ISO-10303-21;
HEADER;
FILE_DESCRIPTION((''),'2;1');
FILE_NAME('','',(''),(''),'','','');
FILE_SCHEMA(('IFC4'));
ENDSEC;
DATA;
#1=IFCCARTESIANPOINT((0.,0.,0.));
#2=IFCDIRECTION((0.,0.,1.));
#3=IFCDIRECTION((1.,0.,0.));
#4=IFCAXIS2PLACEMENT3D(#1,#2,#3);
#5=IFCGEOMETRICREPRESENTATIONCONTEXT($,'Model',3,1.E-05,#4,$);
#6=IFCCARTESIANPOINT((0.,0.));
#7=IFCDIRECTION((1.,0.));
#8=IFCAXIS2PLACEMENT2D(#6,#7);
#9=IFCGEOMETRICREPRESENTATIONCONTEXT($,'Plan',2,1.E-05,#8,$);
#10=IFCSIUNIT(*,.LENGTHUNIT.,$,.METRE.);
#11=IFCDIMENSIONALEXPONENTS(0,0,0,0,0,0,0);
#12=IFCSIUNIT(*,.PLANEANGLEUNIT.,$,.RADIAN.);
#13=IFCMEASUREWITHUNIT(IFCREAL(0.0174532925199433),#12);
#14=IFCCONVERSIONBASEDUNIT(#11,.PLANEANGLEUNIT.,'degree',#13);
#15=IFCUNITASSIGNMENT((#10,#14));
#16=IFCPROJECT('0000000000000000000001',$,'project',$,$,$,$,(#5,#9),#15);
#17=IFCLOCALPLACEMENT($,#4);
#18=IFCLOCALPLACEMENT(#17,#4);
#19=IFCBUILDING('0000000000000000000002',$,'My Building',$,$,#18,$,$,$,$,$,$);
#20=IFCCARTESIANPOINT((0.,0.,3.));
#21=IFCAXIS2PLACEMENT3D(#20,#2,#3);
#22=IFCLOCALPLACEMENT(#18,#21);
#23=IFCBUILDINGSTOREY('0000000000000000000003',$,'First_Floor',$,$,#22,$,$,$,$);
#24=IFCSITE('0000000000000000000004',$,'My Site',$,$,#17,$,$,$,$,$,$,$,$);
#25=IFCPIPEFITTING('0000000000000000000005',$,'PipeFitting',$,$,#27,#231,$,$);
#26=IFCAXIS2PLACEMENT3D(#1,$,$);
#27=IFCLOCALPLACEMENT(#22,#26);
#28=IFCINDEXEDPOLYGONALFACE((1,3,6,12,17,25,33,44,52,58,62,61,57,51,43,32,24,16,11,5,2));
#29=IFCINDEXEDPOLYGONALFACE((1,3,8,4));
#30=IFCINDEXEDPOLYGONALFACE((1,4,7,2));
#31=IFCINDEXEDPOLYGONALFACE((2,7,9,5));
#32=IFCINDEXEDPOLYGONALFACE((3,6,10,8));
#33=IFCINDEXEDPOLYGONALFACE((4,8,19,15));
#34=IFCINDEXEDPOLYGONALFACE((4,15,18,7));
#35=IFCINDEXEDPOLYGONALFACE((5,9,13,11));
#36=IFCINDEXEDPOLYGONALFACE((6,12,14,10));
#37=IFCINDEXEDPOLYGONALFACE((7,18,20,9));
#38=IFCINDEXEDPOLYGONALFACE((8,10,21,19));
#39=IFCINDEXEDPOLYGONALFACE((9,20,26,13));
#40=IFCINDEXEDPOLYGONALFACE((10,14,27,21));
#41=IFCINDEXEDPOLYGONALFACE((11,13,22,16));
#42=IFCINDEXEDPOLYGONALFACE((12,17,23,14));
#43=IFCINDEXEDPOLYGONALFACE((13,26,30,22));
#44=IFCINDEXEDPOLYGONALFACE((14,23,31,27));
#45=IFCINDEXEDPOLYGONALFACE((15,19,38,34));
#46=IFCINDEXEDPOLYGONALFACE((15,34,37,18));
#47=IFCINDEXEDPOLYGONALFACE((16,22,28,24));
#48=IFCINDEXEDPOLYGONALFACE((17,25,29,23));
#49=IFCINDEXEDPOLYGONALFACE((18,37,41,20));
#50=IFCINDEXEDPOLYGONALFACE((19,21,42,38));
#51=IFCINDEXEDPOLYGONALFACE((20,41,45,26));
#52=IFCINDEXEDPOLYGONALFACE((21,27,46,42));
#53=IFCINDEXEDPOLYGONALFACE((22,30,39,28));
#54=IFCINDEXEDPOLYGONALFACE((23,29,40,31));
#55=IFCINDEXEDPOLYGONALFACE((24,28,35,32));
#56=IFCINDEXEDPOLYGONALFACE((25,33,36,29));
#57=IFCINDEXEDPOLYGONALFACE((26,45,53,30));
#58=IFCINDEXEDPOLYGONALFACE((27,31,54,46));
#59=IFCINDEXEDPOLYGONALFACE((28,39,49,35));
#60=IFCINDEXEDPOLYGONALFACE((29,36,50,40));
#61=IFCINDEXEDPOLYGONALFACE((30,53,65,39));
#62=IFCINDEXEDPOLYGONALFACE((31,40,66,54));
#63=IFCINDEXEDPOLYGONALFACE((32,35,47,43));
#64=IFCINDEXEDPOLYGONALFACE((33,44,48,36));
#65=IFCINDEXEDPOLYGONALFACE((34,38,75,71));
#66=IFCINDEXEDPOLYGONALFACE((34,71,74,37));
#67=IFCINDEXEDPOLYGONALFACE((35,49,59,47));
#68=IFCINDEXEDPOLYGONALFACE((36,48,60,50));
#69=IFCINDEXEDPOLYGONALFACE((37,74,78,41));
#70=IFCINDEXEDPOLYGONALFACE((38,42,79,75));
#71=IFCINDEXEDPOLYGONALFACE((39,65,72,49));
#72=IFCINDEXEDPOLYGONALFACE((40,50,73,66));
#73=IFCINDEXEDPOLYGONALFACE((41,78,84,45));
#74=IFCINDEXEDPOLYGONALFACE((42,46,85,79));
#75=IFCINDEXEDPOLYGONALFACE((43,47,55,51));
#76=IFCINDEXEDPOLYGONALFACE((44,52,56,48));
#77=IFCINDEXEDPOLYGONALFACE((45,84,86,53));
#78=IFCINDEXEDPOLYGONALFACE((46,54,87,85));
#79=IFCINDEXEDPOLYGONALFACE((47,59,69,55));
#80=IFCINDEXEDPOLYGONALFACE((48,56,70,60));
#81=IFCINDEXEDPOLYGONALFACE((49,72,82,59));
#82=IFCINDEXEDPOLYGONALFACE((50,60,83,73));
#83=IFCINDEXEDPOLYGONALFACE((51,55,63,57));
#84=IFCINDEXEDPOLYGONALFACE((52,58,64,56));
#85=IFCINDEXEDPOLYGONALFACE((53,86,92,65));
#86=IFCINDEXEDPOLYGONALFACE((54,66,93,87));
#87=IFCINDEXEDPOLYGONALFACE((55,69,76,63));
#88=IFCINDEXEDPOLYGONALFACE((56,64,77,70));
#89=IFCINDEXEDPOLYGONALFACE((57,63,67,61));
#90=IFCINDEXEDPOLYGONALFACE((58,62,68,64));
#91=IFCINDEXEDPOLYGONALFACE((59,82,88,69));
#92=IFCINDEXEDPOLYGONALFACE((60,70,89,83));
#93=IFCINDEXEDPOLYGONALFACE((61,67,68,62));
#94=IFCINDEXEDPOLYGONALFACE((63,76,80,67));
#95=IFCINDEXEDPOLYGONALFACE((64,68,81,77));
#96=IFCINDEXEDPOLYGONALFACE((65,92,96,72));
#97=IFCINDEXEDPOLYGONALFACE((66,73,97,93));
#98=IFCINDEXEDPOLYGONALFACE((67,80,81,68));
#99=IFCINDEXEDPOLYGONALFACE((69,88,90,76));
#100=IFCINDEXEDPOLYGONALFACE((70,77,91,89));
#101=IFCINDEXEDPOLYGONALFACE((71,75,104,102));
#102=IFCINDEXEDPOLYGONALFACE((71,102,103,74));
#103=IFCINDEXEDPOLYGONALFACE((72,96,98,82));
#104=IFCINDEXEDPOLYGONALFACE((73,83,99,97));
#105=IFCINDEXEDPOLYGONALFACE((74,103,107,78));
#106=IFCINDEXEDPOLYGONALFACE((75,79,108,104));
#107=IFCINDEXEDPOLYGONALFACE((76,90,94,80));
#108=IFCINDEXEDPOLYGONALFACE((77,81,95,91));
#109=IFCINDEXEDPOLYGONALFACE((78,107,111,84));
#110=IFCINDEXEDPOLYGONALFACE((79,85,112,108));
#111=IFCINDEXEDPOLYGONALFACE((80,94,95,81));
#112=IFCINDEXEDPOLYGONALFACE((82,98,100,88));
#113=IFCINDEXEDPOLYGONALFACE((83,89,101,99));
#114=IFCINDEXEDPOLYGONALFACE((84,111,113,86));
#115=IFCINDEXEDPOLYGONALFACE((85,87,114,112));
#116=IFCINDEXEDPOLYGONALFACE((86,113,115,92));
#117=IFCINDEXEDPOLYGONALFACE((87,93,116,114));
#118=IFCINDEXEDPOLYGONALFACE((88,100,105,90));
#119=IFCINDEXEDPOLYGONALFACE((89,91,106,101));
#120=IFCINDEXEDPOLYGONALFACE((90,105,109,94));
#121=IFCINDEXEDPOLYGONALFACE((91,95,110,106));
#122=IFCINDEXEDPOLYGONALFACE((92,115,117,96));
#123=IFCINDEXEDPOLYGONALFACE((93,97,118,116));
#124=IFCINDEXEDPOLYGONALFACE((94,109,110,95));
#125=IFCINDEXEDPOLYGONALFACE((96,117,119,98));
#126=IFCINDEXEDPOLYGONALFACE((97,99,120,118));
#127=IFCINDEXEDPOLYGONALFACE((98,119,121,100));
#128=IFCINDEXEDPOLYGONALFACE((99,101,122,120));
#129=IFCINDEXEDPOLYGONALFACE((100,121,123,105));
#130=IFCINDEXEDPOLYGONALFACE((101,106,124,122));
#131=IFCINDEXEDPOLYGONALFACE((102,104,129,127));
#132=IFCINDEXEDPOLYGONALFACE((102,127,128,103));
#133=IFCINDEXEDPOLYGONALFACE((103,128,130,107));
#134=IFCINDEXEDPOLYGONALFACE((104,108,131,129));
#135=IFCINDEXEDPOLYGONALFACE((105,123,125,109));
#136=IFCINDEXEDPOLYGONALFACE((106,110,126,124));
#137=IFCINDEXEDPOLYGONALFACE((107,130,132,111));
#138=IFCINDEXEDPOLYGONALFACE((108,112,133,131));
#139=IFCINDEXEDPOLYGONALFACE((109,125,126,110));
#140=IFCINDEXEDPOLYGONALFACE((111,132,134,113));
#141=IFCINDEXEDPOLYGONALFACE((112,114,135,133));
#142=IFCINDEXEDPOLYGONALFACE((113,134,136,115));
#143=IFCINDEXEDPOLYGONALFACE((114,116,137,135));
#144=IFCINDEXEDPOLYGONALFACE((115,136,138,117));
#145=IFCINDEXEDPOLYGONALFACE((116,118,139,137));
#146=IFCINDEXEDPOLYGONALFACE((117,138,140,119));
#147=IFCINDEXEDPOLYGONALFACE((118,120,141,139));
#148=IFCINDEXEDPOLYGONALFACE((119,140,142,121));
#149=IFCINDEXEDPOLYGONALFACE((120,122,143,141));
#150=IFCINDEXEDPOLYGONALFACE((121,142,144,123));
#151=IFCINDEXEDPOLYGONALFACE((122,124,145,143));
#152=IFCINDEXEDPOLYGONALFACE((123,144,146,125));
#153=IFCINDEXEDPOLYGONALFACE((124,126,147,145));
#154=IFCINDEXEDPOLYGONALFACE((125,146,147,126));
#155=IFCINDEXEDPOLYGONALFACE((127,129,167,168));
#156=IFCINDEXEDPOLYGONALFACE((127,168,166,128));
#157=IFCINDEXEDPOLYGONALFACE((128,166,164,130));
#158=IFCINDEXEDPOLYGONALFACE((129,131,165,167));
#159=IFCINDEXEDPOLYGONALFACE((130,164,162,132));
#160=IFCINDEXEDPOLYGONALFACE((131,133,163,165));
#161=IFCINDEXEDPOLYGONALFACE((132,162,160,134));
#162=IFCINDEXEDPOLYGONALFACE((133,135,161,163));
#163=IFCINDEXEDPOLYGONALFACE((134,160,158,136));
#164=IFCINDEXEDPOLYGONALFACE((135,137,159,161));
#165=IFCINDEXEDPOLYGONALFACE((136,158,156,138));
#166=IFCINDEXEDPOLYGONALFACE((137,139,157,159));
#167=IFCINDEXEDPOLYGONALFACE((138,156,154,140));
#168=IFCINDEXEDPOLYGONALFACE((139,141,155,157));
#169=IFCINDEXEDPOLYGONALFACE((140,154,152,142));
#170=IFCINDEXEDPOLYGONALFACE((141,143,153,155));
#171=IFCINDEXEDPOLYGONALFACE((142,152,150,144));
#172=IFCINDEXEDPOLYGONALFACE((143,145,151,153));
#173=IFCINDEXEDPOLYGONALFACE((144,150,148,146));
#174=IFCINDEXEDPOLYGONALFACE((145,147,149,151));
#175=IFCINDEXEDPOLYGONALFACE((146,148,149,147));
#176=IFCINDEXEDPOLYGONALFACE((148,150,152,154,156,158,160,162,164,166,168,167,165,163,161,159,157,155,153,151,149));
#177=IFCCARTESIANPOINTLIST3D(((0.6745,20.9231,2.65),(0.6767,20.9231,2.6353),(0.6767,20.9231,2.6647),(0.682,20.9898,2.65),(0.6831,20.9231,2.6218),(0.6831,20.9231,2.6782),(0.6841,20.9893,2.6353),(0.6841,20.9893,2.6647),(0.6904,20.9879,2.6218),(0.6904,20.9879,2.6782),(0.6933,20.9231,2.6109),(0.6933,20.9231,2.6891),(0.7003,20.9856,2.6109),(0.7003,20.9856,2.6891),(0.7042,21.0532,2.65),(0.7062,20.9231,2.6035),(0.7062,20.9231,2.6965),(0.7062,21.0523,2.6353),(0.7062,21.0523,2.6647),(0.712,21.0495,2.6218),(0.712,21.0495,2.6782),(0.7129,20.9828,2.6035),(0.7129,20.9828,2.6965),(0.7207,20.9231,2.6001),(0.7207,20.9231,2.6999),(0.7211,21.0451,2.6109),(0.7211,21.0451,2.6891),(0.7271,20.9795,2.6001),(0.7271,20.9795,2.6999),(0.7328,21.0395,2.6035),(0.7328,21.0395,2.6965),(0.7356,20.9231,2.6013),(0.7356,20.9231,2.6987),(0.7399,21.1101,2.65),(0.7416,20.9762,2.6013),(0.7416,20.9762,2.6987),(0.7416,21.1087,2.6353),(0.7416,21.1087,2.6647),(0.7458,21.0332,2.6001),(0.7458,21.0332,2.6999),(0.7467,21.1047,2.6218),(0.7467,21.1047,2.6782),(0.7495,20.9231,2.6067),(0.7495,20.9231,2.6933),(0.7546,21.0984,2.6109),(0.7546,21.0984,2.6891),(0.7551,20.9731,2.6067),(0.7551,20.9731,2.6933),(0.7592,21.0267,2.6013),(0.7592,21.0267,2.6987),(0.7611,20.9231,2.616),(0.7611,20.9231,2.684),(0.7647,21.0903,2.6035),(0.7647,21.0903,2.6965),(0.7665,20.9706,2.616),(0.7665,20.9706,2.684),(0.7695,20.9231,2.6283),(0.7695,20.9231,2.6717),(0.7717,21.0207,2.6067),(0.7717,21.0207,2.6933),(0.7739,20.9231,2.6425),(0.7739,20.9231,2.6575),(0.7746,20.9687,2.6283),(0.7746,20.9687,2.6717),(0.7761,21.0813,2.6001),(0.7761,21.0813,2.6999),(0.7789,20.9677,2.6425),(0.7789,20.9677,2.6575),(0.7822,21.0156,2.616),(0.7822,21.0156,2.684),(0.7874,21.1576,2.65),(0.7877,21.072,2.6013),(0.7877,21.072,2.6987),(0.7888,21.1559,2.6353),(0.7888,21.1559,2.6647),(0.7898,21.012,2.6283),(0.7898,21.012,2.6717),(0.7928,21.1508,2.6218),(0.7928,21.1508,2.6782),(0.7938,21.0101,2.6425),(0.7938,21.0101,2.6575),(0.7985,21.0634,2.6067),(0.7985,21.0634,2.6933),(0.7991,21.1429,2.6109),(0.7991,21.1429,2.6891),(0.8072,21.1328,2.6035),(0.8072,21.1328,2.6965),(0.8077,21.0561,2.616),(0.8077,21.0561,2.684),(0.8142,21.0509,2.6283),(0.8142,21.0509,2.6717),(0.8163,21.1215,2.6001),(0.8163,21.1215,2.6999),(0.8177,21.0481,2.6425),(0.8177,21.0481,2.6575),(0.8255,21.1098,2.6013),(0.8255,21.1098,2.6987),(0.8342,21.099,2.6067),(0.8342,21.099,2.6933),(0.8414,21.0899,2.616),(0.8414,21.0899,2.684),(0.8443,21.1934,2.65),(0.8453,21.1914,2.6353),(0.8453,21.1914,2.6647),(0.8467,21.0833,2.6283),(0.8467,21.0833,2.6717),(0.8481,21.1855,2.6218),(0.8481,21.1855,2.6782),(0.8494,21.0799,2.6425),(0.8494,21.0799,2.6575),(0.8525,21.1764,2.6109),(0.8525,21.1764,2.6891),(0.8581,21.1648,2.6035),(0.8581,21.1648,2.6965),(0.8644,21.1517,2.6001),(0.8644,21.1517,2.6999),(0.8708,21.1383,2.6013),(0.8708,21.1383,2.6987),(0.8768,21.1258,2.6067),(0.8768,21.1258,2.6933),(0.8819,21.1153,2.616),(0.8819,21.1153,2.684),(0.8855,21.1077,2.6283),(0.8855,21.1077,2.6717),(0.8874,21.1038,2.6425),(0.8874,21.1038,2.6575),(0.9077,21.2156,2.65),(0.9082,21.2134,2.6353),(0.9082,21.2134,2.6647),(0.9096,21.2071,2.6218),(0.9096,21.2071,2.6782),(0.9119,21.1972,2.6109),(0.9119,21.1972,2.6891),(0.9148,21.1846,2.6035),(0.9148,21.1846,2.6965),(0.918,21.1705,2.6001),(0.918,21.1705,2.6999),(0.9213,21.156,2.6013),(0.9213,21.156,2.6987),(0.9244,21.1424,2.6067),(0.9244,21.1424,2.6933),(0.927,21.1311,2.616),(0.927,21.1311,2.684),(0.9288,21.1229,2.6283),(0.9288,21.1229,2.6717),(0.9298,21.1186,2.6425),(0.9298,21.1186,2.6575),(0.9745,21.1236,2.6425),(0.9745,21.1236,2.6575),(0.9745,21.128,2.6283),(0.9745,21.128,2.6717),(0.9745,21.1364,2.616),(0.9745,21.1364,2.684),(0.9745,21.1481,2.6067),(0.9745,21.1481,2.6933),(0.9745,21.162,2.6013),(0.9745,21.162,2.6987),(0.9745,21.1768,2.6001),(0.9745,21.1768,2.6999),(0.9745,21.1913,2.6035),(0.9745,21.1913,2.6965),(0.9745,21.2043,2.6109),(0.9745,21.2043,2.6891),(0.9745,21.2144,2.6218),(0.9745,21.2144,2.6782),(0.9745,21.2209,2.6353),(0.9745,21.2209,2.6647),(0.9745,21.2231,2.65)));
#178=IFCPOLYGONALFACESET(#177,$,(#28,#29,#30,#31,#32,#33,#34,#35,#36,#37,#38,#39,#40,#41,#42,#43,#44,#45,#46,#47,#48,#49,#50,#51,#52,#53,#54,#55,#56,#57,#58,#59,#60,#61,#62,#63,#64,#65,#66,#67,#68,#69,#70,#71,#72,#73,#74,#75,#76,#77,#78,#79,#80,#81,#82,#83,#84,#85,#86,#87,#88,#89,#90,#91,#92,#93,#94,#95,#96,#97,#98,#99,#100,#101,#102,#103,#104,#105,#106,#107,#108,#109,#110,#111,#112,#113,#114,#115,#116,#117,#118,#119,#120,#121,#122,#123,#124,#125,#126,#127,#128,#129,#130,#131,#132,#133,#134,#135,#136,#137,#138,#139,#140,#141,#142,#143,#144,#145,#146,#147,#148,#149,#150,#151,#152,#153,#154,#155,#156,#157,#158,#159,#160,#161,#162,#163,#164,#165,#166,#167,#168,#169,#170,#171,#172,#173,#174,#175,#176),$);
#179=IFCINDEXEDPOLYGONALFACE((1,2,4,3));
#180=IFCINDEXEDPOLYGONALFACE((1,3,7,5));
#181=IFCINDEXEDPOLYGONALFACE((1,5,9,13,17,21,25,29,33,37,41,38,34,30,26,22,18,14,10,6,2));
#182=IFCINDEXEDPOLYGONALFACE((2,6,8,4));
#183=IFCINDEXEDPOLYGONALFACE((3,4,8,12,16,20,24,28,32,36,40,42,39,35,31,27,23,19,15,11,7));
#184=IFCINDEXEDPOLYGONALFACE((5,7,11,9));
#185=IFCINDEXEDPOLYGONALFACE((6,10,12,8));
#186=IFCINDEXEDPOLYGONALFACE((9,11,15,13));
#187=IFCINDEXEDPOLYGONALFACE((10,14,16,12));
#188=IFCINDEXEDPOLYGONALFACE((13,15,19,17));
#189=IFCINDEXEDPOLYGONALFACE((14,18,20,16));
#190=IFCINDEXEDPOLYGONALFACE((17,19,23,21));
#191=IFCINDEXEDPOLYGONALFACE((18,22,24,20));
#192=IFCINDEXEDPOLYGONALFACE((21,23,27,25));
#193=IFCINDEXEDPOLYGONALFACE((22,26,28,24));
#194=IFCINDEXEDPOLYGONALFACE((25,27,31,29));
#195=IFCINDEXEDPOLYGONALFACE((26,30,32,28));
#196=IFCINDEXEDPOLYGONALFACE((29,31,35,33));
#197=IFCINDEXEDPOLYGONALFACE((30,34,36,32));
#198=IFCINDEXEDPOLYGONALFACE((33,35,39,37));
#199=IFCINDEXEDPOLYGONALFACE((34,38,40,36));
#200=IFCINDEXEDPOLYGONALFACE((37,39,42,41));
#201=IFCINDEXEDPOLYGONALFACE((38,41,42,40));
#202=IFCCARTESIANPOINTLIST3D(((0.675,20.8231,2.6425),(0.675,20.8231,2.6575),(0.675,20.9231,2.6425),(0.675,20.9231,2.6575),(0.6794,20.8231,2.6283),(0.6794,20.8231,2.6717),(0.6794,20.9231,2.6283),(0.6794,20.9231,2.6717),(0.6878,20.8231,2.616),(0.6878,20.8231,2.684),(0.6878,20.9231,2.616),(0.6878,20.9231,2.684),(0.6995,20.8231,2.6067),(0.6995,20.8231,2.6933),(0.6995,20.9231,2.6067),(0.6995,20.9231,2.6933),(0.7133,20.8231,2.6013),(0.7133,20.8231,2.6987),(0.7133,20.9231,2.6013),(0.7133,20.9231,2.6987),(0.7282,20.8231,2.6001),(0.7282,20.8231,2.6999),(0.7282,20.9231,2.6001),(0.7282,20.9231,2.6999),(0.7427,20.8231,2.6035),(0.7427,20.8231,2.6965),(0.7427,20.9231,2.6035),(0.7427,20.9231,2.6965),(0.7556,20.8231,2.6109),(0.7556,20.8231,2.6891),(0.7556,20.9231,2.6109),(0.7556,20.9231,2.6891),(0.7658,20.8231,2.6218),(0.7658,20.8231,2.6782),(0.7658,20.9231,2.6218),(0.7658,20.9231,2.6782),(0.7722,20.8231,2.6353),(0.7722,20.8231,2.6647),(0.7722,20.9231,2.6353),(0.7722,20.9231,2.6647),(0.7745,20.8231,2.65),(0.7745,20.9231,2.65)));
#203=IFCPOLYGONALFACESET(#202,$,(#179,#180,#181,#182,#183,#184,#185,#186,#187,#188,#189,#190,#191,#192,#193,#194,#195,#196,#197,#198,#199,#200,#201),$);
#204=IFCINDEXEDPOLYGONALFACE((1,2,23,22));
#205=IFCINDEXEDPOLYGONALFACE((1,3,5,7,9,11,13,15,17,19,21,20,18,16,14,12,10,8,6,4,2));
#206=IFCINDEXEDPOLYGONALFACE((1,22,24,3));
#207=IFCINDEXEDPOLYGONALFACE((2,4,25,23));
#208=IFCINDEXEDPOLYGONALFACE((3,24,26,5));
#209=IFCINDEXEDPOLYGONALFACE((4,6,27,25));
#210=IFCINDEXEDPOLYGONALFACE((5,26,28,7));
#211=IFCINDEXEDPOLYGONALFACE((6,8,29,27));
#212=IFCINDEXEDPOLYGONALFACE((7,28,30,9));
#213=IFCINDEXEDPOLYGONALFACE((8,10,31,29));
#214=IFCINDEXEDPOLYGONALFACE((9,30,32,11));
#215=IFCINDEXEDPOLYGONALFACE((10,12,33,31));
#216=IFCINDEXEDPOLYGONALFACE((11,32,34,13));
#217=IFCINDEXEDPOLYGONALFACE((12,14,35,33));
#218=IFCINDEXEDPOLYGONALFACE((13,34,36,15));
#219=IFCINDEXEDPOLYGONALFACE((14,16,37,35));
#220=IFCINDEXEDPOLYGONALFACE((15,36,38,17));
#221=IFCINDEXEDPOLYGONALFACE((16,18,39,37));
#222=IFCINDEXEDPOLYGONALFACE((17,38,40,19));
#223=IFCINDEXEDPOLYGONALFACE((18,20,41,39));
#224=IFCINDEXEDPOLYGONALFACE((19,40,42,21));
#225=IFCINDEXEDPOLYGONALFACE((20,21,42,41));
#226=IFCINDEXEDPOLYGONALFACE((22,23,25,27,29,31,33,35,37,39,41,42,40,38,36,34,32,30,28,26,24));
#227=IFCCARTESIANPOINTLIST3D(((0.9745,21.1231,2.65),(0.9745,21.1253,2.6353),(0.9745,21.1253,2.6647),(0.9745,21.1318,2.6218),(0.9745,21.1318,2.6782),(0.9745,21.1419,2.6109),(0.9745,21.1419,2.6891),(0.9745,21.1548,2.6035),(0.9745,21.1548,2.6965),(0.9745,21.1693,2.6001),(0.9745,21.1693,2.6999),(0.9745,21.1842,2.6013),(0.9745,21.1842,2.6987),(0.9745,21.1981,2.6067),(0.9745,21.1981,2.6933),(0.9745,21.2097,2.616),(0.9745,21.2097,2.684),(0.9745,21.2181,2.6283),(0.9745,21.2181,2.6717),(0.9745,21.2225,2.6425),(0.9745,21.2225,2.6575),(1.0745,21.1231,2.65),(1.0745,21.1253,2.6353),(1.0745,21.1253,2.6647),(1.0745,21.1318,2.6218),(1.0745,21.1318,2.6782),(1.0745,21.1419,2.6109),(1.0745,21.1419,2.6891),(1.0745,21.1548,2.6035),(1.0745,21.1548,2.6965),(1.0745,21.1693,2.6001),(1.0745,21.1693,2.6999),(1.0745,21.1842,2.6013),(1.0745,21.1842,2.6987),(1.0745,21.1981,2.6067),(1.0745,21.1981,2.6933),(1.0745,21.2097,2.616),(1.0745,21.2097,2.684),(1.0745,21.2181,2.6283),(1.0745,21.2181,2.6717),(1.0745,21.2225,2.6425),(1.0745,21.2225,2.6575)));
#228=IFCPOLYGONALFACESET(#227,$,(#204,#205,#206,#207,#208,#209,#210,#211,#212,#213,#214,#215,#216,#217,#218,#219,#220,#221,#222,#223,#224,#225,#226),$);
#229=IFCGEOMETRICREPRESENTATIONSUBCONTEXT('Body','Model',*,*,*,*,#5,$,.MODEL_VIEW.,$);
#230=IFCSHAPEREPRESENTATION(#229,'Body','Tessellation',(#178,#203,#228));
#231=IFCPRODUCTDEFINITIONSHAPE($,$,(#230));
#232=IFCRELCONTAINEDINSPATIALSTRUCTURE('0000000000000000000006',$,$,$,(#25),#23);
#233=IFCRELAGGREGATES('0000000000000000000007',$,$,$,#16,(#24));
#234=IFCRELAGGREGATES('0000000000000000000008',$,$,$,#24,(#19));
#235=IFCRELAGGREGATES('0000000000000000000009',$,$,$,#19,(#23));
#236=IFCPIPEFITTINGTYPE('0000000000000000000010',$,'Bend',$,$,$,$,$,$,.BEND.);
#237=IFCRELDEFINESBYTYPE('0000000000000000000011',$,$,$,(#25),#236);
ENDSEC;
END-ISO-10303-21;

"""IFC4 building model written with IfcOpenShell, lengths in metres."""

from ifc_helpers import new_model, entity, si_unit, converted_unit, frame, origin_with_axes, origin_2d_with_axis, place, context, subcontext, project, spatial, circle, extrude, source, transform, mapped, type_object, type_shapes, element, save


model = new_model("IFC4")

# Units and contexts
model_context = context("Model", 3, precision=1e-05, world=origin_with_axes())
plan_context = context("Plan", 2, precision=1e-05, world=origin_2d_with_axis())
body_context = subcontext(model_context, "Body", "Model", "MODEL_VIEW")
ifc_project = project(units=[si_unit("LENGTHUNIT", "METRE"), converted_unit("PLANEANGLEUNIT", "degree", entity("IfcReal", 0.0174532925199433), si_unit("PLANEANGLEUNIT", "RADIAN"), dimensions=[0, 0, 0, 0, 0, 0, 0])], contexts=[model_context, plan_context])

# Site, building, storey
site_placement = place(None, origin_with_axes())
site = spatial("IfcSite", under=ifc_project, at=site_placement, Name="My Site")
building_placement = place(site_placement, origin_with_axes())
building = spatial("IfcBuilding", under=site, at=building_placement, Name="My Building")
storey_placement = place(building_placement, frame((0.0, 0.0, 3.0), z_axis=(0.0, 0.0, 1.0), x_axis=(1.0, 0.0, 0.0)))
storey = spatial("IfcBuildingStorey", under=building, at=storey_placement, Name="First_Floor")

# Pipe fitting
pipe_fitting_type = type_object("IfcPipeFittingType", Name="Bend", PredefinedType="BEND")
shared_shape = source(origin_with_axes(), body_context, "Body", "SolidModel", [
    entity("IfcSweptDiskSolid", entity("IfcIndexedPolyCurve", entity("IfcCartesianPointList3D", [[0.0, 0.0, -0.1], [0.0732, 0.0, -0.2768], [0.25, 0.0, -0.35]]), [entity("IfcArcIndex", [1, 2, 3])]), 0.05),
    extrude(circle(Radius=0.05), origin_with_axes(), (0.0, 0.0, -1.0), 0.1),
    extrude(circle(Radius=0.05), frame((0.25, 0.0, -0.35), z_axis=(1.0, 0.0, 0.0), x_axis=(0.0, 0.0, 1.0)), (0.0, 0.0, 1.0), 0.1),
])
type_shapes(pipe_fitting_type, [shared_shape])
for number, where, z_axis, x_axis, name in (
    (1, (0.7245, 20.8231, 2.65), (0.0, -1.0, 0.0), (1.0, 0.0, 0.0), "PipeFitting"),
):
    element("IfcPipeFitting", number, at=place(storey_placement, frame(where, z_axis=z_axis, x_axis=x_axis)), inside=storey, type_object=pipe_fitting_type, Name=name, context=body_context, shape_type="MappedRepresentation", body=[
        mapped(shared_shape, transform((0.0, 0.0, 0.0), x_axis=(1.0, 0.0, 0.0), y_axis=(0.0, 1.0, 0.0), z_axis=(0.0, 0.0, 1.0), scale=1.0)),
    ])

save(model, "model.ifc")
